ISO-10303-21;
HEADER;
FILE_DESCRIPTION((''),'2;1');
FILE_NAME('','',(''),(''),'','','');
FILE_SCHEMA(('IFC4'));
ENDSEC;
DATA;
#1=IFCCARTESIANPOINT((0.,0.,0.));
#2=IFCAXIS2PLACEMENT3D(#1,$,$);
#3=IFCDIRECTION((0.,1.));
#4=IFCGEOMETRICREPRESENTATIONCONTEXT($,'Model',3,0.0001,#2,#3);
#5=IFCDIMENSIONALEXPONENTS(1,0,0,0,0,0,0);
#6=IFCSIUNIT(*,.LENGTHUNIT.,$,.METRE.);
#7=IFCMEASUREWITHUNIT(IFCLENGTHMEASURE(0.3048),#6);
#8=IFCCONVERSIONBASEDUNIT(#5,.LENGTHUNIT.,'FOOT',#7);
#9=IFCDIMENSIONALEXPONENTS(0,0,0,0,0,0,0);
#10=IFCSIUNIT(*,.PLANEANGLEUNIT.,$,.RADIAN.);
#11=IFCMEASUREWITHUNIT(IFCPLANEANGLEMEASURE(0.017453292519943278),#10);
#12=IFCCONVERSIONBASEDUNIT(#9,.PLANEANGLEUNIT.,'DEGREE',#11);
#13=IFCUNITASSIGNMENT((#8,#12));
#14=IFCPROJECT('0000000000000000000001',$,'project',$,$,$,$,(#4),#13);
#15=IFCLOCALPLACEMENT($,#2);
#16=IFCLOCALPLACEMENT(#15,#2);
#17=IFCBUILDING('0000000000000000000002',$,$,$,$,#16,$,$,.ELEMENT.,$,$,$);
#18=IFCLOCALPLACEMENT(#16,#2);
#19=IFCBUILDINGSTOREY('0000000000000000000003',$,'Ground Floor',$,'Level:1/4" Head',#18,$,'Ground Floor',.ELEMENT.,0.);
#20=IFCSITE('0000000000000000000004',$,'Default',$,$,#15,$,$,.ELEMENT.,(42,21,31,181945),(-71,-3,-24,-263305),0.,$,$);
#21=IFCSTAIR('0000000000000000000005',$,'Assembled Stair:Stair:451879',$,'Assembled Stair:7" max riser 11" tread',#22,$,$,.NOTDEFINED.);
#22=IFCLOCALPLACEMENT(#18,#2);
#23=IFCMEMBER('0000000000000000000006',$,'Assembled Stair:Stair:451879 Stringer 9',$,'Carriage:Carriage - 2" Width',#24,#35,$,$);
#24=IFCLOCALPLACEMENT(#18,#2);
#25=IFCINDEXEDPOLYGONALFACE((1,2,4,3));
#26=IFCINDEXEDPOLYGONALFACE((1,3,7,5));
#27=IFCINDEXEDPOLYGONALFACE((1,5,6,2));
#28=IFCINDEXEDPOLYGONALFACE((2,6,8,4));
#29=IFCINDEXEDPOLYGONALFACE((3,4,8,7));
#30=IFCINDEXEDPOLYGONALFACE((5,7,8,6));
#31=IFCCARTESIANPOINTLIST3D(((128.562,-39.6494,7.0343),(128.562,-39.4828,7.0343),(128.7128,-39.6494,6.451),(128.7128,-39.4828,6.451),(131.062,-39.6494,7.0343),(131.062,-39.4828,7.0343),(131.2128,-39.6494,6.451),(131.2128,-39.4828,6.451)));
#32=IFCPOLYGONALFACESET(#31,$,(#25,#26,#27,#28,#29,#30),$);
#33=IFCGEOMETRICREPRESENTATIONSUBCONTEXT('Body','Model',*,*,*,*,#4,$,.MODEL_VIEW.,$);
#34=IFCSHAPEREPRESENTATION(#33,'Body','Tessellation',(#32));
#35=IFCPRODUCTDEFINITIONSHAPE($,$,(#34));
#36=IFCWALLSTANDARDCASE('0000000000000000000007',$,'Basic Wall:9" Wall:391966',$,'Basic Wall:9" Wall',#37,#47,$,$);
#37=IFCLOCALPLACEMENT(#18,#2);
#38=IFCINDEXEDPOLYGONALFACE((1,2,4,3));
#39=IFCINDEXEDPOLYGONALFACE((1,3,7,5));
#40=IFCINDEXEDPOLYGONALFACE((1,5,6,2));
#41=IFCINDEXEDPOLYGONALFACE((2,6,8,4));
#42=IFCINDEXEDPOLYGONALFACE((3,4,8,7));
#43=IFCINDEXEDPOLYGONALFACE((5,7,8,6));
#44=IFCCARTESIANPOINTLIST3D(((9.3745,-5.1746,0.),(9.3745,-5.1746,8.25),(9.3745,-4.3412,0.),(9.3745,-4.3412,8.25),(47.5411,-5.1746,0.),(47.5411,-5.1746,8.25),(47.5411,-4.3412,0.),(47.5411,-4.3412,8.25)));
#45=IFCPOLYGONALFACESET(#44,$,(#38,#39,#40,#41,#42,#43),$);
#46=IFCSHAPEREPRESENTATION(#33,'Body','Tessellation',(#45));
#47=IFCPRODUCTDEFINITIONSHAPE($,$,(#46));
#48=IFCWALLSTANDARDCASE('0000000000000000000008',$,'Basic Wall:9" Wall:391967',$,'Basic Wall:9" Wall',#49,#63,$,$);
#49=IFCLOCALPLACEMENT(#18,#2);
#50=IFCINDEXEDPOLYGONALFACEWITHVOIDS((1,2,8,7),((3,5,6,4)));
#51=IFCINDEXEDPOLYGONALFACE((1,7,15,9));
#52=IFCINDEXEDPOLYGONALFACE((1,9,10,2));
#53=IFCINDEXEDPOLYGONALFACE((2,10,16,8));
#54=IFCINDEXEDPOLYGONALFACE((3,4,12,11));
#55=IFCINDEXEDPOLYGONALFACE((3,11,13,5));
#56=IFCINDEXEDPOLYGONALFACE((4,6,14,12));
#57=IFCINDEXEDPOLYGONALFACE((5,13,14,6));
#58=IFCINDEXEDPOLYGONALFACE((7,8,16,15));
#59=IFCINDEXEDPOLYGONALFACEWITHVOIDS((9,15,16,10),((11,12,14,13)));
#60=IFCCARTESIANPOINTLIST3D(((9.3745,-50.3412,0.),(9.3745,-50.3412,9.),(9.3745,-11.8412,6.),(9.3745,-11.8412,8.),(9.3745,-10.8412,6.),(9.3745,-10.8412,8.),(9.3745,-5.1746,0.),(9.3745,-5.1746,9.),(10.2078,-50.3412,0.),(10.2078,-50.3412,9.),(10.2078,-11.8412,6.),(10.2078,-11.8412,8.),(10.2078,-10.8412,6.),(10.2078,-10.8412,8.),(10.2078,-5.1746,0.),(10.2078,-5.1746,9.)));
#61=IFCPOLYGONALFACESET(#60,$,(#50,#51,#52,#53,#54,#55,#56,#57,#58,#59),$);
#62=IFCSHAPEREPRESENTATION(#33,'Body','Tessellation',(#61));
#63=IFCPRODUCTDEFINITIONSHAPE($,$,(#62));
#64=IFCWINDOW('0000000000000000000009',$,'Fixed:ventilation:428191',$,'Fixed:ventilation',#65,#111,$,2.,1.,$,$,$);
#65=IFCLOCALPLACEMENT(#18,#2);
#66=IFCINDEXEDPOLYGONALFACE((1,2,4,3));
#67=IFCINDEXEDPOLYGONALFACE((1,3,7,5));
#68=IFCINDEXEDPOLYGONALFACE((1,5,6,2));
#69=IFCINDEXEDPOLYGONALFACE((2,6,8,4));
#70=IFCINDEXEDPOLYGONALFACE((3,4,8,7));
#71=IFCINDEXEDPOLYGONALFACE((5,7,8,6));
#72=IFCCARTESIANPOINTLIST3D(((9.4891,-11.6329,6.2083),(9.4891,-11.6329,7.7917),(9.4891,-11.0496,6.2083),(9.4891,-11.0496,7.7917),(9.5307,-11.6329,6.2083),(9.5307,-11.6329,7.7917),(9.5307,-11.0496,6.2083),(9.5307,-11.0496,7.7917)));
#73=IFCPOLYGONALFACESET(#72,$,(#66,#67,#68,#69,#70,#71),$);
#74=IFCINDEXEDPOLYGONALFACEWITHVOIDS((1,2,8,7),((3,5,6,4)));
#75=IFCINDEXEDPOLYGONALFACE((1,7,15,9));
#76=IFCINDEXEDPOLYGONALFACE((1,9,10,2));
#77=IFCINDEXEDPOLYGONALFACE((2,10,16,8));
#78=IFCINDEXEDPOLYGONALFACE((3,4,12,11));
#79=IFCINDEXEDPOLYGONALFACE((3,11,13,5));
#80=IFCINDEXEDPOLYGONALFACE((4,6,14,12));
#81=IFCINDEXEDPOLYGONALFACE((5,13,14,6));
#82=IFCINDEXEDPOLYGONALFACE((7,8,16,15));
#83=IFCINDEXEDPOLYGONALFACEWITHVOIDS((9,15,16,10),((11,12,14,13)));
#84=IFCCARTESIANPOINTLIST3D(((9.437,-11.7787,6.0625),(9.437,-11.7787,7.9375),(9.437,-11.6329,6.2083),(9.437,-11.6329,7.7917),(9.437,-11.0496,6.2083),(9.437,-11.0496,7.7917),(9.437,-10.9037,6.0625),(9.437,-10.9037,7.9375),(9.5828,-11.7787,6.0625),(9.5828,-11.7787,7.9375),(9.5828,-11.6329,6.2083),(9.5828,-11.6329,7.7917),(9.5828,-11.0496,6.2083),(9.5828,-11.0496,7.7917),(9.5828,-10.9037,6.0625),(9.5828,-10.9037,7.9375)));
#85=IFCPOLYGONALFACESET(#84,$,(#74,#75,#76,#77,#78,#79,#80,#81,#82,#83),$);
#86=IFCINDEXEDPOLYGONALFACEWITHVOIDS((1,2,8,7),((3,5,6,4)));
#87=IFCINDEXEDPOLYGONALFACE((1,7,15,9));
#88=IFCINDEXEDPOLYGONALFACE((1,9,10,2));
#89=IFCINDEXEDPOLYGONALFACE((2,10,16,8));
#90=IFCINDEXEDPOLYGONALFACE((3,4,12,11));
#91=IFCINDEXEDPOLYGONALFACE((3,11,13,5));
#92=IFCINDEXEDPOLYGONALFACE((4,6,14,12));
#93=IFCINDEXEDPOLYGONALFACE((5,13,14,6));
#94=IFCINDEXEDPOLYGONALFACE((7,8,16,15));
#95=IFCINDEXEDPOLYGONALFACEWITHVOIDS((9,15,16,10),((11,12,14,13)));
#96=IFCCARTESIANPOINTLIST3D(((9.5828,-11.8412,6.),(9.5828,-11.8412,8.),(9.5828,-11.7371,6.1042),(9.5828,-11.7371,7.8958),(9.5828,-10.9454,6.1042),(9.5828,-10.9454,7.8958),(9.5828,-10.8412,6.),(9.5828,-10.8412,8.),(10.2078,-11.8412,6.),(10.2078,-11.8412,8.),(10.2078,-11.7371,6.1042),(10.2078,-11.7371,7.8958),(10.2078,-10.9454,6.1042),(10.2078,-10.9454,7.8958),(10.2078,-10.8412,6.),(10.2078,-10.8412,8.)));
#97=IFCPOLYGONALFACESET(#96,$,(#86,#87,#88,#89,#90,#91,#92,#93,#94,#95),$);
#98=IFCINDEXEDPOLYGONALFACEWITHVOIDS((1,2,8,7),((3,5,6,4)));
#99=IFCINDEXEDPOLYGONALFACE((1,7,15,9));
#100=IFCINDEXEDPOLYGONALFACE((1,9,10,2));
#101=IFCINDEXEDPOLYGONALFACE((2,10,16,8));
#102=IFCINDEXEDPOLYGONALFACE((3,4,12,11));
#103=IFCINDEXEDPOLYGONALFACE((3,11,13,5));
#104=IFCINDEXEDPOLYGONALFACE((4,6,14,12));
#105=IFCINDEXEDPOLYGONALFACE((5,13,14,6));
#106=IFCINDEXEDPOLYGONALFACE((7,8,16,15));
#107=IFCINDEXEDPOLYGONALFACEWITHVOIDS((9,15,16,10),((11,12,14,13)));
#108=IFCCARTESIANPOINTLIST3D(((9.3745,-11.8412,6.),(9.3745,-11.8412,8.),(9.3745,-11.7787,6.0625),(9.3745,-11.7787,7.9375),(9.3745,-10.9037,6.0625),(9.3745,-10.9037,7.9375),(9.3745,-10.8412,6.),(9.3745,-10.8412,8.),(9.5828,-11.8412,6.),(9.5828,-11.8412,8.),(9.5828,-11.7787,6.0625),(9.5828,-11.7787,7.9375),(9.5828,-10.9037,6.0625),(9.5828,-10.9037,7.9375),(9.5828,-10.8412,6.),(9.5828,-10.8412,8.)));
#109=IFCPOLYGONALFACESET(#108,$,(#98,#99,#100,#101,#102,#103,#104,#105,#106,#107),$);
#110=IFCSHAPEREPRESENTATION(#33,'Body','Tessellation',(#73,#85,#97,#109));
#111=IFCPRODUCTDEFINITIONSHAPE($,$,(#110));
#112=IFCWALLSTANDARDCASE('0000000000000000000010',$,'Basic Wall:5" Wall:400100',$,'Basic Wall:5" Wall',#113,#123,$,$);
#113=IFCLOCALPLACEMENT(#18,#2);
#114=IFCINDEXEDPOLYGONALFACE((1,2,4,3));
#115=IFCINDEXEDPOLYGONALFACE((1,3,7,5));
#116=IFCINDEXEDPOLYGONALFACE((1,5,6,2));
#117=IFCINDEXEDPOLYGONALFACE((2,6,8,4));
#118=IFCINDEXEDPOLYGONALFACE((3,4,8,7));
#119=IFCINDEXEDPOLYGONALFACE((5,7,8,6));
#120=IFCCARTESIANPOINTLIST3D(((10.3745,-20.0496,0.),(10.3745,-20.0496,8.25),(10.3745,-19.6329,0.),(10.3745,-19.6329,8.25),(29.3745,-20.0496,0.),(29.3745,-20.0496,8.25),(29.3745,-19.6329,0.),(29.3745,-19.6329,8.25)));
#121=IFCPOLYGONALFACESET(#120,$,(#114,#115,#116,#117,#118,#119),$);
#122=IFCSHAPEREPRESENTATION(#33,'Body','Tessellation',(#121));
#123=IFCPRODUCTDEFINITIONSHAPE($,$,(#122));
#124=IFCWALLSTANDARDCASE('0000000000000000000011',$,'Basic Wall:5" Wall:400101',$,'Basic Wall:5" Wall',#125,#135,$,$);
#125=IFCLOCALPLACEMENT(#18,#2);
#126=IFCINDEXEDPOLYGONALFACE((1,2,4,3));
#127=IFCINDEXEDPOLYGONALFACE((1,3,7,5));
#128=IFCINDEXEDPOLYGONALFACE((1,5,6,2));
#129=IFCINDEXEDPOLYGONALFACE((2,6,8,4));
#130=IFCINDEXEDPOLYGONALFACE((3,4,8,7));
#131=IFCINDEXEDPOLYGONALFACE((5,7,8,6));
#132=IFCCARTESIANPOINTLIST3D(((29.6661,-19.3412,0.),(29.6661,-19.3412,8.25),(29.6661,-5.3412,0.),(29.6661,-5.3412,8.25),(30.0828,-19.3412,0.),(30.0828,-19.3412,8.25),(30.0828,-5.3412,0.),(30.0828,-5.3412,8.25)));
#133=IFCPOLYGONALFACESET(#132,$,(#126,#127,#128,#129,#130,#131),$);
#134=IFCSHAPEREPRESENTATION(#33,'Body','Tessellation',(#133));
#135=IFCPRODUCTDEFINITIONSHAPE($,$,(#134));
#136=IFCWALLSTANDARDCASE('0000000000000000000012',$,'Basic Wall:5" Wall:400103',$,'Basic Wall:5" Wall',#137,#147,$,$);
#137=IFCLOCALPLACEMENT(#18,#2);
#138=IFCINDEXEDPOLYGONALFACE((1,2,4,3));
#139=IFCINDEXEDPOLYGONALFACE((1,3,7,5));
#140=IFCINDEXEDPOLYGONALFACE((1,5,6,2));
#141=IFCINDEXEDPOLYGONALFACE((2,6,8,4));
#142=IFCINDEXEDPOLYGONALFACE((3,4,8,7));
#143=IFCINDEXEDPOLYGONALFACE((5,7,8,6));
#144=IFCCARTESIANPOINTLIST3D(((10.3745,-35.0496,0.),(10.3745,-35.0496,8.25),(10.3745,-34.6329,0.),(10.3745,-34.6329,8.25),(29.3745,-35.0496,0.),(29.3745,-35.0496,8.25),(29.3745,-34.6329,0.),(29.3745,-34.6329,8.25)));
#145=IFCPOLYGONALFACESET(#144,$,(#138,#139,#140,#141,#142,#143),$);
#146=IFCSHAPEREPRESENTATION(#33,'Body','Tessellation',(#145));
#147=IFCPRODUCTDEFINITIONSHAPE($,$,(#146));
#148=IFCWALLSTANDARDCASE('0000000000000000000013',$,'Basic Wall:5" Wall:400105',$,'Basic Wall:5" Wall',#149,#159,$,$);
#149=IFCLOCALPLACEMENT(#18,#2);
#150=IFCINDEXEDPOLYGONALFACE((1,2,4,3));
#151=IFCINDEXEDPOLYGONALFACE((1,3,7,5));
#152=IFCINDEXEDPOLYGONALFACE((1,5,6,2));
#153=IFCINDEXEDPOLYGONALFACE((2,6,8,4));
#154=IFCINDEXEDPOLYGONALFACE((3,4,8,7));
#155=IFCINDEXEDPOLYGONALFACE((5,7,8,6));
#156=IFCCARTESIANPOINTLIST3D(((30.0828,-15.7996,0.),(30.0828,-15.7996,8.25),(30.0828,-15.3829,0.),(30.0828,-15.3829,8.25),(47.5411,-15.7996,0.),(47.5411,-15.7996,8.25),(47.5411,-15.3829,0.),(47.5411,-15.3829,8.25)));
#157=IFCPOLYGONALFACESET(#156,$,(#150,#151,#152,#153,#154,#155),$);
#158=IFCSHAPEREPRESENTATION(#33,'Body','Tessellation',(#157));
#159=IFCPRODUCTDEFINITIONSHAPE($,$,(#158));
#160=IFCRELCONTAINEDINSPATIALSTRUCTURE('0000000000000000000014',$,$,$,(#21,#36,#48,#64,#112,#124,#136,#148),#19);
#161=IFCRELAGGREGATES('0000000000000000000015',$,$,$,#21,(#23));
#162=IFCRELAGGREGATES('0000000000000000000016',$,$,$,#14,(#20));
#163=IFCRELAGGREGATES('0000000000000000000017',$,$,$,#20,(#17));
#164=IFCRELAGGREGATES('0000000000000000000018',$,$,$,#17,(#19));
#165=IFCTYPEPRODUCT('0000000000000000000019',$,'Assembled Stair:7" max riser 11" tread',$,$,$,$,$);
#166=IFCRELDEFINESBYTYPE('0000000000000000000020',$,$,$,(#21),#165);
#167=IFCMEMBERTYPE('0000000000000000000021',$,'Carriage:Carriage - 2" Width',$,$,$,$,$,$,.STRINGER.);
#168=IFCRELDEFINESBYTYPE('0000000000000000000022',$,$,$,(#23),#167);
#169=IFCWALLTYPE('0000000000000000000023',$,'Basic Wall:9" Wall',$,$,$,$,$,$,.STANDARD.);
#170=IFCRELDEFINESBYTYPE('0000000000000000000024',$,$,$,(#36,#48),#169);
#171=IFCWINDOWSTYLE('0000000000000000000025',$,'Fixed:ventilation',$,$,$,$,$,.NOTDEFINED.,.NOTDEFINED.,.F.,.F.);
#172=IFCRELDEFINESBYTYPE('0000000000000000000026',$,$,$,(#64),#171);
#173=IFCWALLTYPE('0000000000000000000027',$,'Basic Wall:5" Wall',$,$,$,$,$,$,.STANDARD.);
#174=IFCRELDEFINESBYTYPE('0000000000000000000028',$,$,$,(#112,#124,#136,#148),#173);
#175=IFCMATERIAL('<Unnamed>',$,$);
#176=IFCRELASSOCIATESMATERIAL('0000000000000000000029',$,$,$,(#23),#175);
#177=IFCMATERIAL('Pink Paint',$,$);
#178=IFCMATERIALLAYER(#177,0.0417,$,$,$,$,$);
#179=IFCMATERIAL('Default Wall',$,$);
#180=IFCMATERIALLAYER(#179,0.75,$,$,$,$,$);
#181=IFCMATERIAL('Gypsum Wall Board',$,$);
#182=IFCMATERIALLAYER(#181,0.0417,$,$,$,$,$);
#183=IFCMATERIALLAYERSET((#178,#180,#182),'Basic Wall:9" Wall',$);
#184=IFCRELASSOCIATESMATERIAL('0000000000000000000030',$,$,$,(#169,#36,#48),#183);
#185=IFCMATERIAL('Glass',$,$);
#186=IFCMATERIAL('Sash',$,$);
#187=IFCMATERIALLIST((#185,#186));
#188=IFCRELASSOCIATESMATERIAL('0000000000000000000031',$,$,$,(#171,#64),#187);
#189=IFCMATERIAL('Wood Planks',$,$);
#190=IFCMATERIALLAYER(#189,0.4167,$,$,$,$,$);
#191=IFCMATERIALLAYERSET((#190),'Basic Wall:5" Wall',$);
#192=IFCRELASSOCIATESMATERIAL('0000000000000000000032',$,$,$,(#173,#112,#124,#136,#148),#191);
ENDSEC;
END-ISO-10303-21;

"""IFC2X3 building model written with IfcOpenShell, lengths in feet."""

from ifc_helpers import new_model, entity, si_unit, converted_unit, direction, frame, frame_2d, origin, origin_2d_with_axis, place, context, subcontext, project, spatial, polyline, rectangle, outline, extrude, clip, bounded_halfspace, source, transform, mapped, material, material_list, layer, layer_set, layer_usage, type_object, type_shapes, element, fill, aggregate, save


model = new_model("IFC2X3")

# Units and contexts
model_context = context("Model", 3, precision=0.0001, world=origin(), true_north=direction((0.0, 1.0)))
body_context = subcontext(model_context, "Body", "Model", "MODEL_VIEW")
ifc_project = project(units=[converted_unit("LENGTHUNIT", "FOOT", entity("IfcLengthMeasure", 0.3048), si_unit("LENGTHUNIT", "METRE"), dimensions=[1, 0, 0, 0, 0, 0, 0]), converted_unit("PLANEANGLEUNIT", "DEGREE", entity("IfcPlaneAngleMeasure", 0.017453292519943278), si_unit("PLANEANGLEUNIT", "RADIAN"), dimensions=[0, 0, 0, 0, 0, 0, 0])], contexts=[model_context])

# Site, building, storey
site_placement = place(None, origin())
site = spatial("IfcSite", under=ifc_project, at=site_placement, Name="Default", CompositionType="ELEMENT", RefLatitude=(42, 21, 31, 181945), RefLongitude=(-71, -3, -24, -263305), RefElevation=0.0)
building_placement = place(site_placement, origin())
building = spatial("IfcBuilding", under=site, at=building_placement, CompositionType="ELEMENT")
storey_placement = place(building_placement, origin())
storey = spatial("IfcBuildingStorey", under=building, at=storey_placement, Name="Ground Floor", ObjectType="Level:1/4\" Head", LongName="Ground Floor", CompositionType="ELEMENT", Elevation=0.0)

# Stair, member
type_product = type_object("IfcTypeProduct", Name="Assembled Stair:7\" max riser 11\" tread")
stair_placement = place(storey_placement, origin())
stair = element("IfcStair", 1, at=stair_placement, inside=storey, type_object=type_product, Name="Assembled Stair:Stair:451879", ObjectType="Assembled Stair:7\" max riser 11\" tread", ShapeType="NOTDEFINED")
ifc_material_1 = material(Name="<Unnamed>")
member_type = type_object("IfcMemberType", Name="Carriage:Carriage - 2\" Width", PredefinedType="STRINGER")
member_1_placement = place(stair_placement, origin())
member_1 = element("IfcMember", 2, at=member_1_placement, type_object=member_type, material=ifc_material_1, Name="Assembled Stair:Stair:451879 Stringer 9", ObjectType="Carriage:Carriage - 2\" Width", context=body_context, shape_type="SweptSolid", body=[
    extrude(outline(polyline([(0.0115, -1.2102), (0.614, -1.2102), (-0.0115, 1.2102), (-0.614, 1.2102), (0.0115, -1.2102)])), frame((129.8874, -39.6494, 6.7426), z_axis=(0.0, 1.0, 0.0), x_axis=(-0.250236, 0.0, 0.968185)), (0.0, 0.0, 1.0), 0.1667),
])

# Wall
ifc_material_2 = material(Name="Pink Paint")
ifc_layer_1 = layer(ifc_material_2, 0.0417)
ifc_material_3 = material(Name="Default Wall")
ifc_layer_2 = layer(ifc_material_3, 0.75)
ifc_material_4 = material(Name="Gypsum Wall Board")
ifc_layer_3 = layer(ifc_material_4, 0.0417)
ifc_layer_set_1 = layer_set([ifc_layer_1, ifc_layer_2, ifc_layer_3], Name="Basic Wall:9\" Wall")
ifc_layer_usage_1 = layer_usage(ifc_layer_set_1, "AXIS2", "NEGATIVE", 0.4167)
wall_type_1 = type_object("IfcWallType", Name="Basic Wall:9\" Wall", PredefinedType="STANDARD", material=ifc_layer_set_1)
wall_1_placement = place(storey_placement, frame((9.3745, -4.7579, 0.0)))
element("IfcWallStandardCase", 3, at=wall_1_placement, inside=storey, type_object=wall_type_1, material=ifc_layer_usage_1, Name="Basic Wall:9\" Wall:391966", ObjectType="Basic Wall:9\" Wall", context=body_context, shape_type="SweptSolid", body=[
    extrude(rectangle(XDim=38.1667, YDim=0.8333, at=frame_2d((19.0833, 0.0), x_axis=(-1.0, 0.0))), origin(), (0.0, 0.0, 1.0), 8.25),
])

# Wall, opening, window
wall_2_placement = place(storey_placement, frame((9.7911, -50.3412, 0.0), z_axis=(0.0, 0.0, 1.0), x_axis=(0.0, 1.0, 0.0)))
wall_2 = element("IfcWallStandardCase", 4, at=wall_2_placement, inside=storey, type_object=wall_type_1, material=ifc_layer_usage_1, Name="Basic Wall:9\" Wall:391967", ObjectType="Basic Wall:9\" Wall", context=body_context, shape_type="Clipping", body=[
    clip(extrude(rectangle(XDim=45.1667, YDim=0.8333, at=frame_2d((22.5833, 0.0), x_axis=(-1.0, 0.0))), origin(), (0.0, 0.0, 1.0), 9.0), bounded_halfspace(frame((0.0, -0.4167, 9.0), z_axis=(0.0, 0.0, -1.0), x_axis=(-1.0, 0.0, 0.0)), True, frame((0.0, -0.4167, 9.0)), polyline([(0.0, 0.0), (0.8333, 0.0), (45.1667, 0.0), (45.1667, 0.8333), (0.0, 0.8333), (0.0, 0.0)]))),
])
opening_1_placement = place(wall_2_placement, frame((38.5, -0.4167, 6.0)))
opening_1 = element("IfcOpeningElement", 5, at=opening_1_placement, cuts=wall_2, ObjectType="Opening", context=body_context, shape_type="SweptSolid", body=[
    extrude(rectangle(XDim=2.0, YDim=1.0, at=frame_2d((1.0, 0.5), x_axis=(-1.0, 0.0))), frame((0.0, 0.0, 0.0), z_axis=(0.0, 1.0, 0.0), x_axis=(0.0, 0.0, 1.0)), (0.0, 0.0, 1.0), 0.8333),
])
ifc_material_5 = material(Name="Glass")
ifc_material_6 = material(Name="Sash")
ifc_material_list_1 = material_list([ifc_material_5, ifc_material_6])
window_style = type_object("IfcWindowStyle", Name="Fixed:ventilation", ConstructionType="NOTDEFINED", OperationType="NOTDEFINED", ParameterTakesPrecedence=False, Sizeable=False, material=ifc_material_list_1)
shared_shape_1 = source(origin(), body_context, "Body", "SweptSolid", [
    extrude(rectangle(XDim=0.0417, YDim=0.5833, at=origin_2d_with_axis()), frame((0.5, 0.6979, 0.2083), z_axis=(0.0, 0.0, 1.0), x_axis=(0.0, 1.0, 0.0)), (0.0, 0.0, 1.0), 1.5833),
    extrude(outline(polyline([(-0.4375, -0.9375), (0.4375, -0.9375), (0.4375, 0.9375), (-0.4375, 0.9375), (-0.4375, -0.9375)]), holes=[polyline([(-0.2917, -0.7917), (-0.2917, 0.7917), (0.2917, 0.7917), (0.2917, -0.7917), (-0.2917, -0.7917)])]), frame((0.5, 0.625, 1.0), z_axis=(0.0, 1.0, 0.0), x_axis=(1.0, 0.0, 0.0)), (0.0, 0.0, 1.0), 0.1458),
    extrude(outline(polyline([(-0.5, -1.0), (0.5, -1.0), (0.5, 1.0), (-0.5, 1.0), (-0.5, -1.0)]), holes=[polyline([(-0.3958, -0.8958), (-0.3958, 0.8958), (0.3958, 0.8958), (0.3958, -0.8958), (-0.3958, -0.8958)])]), frame((0.5, 0.0, 1.0), z_axis=(0.0, 1.0, 0.0), x_axis=(1.0, 0.0, 0.0)), (0.0, 0.0, 1.0), 0.625),
    extrude(outline(polyline([(-1.0, -0.5), (1.0, -0.5), (1.0, 0.5), (-1.0, 0.5), (-1.0, -0.5)]), holes=[polyline([(-0.9375, -0.4375), (-0.9375, 0.4375), (0.9375, 0.4375), (0.9375, -0.4375), (-0.9375, -0.4375)])]), frame((0.5, 0.625, 1.0), z_axis=(0.0, 1.0, 0.0), x_axis=(0.0, 0.0, -1.0)), (0.0, 0.0, 1.0), 0.2083),
])
type_shapes(window_style, [shared_shape_1])
window_placement = place(opening_1_placement, origin())
window = element("IfcWindow", 6, at=window_placement, inside=storey, type_object=window_style, material=ifc_material_list_1, Name="Fixed:ventilation:428191", ObjectType="Fixed:ventilation", OverallHeight=2.0, OverallWidth=1.0, context=body_context, shape_type="MappedRepresentation", body=[
    mapped(shared_shape_1, transform((0.0, 0.0, 0.0), scale=1.0)),
])
fill(opening_1, window)

# Walls
ifc_material_7 = material(Name="Wood Planks")
ifc_layer_4 = layer(ifc_material_7, 0.4167)
ifc_layer_set_2 = layer_set([ifc_layer_4], Name="Basic Wall:5\" Wall")
ifc_layer_usage_2 = layer_usage(ifc_layer_set_2, "AXIS2", "NEGATIVE", 0.2083)
wall_type_2 = type_object("IfcWallType", Name="Basic Wall:5\" Wall", PredefinedType="STANDARD", material=ifc_layer_set_2)
wall_3_placement = place(storey_placement, frame((10.3745, -19.8412, 0.0)))
element("IfcWallStandardCase", 7, at=wall_3_placement, inside=storey, type_object=wall_type_2, material=ifc_layer_usage_2, Name="Basic Wall:5\" Wall:400100", ObjectType="Basic Wall:5\" Wall", context=body_context, shape_type="SweptSolid", body=[
    extrude(rectangle(XDim=19.0, YDim=0.4167, at=frame_2d((9.5, 0.0), x_axis=(-1.0, 0.0))), origin(), (0.0, 0.0, 1.0), 8.25),
])
wall_4_placement = place(storey_placement, frame((29.8745, -19.3412, 0.0), z_axis=(0.0, 0.0, 1.0), x_axis=(0.0, 1.0, 0.0)))
element("IfcWallStandardCase", 8, at=wall_4_placement, inside=storey, type_object=wall_type_2, material=ifc_layer_usage_2, Name="Basic Wall:5\" Wall:400101", ObjectType="Basic Wall:5\" Wall", context=body_context, shape_type="SweptSolid", body=[
    extrude(rectangle(XDim=14.0, YDim=0.4167, at=frame_2d((7.0, 0.0), x_axis=(-1.0, 0.0))), origin(), (0.0, 0.0, 1.0), 8.25),
])

# Wall
wall_5_placement = place(storey_placement, frame((29.3745, -34.8412, 0.0), z_axis=(0.0, 0.0, 1.0), x_axis=(-1.0, 0.0, 0.0)))
element("IfcWallStandardCase", 9, at=wall_5_placement, inside=storey, type_object=wall_type_2, material=ifc_layer_usage_2, Name="Basic Wall:5\" Wall:400103", ObjectType="Basic Wall:5\" Wall", context=body_context, shape_type="SweptSolid", body=[
    extrude(rectangle(XDim=19.0, YDim=0.4167, at=frame_2d((9.5, 0.0), x_axis=(-1.0, 0.0))), origin(), (0.0, 0.0, 1.0), 8.25),
])

# Wall
wall_6_placement = place(storey_placement, frame((30.0828, -15.5912, 0.0)))
element("IfcWallStandardCase", 10, at=wall_6_placement, inside=storey, type_object=wall_type_2, material=ifc_layer_usage_2, Name="Basic Wall:5\" Wall:400105", ObjectType="Basic Wall:5\" Wall", context=body_context, shape_type="SweptSolid", body=[
    extrude(rectangle(XDim=17.4583, YDim=0.4167, at=frame_2d((8.7292, 0.0), x_axis=(-1.0, 0.0))), origin(), (0.0, 0.0, 1.0), 8.25),
])

aggregate(stair, [member_1])

save(model, "model.ifc")
